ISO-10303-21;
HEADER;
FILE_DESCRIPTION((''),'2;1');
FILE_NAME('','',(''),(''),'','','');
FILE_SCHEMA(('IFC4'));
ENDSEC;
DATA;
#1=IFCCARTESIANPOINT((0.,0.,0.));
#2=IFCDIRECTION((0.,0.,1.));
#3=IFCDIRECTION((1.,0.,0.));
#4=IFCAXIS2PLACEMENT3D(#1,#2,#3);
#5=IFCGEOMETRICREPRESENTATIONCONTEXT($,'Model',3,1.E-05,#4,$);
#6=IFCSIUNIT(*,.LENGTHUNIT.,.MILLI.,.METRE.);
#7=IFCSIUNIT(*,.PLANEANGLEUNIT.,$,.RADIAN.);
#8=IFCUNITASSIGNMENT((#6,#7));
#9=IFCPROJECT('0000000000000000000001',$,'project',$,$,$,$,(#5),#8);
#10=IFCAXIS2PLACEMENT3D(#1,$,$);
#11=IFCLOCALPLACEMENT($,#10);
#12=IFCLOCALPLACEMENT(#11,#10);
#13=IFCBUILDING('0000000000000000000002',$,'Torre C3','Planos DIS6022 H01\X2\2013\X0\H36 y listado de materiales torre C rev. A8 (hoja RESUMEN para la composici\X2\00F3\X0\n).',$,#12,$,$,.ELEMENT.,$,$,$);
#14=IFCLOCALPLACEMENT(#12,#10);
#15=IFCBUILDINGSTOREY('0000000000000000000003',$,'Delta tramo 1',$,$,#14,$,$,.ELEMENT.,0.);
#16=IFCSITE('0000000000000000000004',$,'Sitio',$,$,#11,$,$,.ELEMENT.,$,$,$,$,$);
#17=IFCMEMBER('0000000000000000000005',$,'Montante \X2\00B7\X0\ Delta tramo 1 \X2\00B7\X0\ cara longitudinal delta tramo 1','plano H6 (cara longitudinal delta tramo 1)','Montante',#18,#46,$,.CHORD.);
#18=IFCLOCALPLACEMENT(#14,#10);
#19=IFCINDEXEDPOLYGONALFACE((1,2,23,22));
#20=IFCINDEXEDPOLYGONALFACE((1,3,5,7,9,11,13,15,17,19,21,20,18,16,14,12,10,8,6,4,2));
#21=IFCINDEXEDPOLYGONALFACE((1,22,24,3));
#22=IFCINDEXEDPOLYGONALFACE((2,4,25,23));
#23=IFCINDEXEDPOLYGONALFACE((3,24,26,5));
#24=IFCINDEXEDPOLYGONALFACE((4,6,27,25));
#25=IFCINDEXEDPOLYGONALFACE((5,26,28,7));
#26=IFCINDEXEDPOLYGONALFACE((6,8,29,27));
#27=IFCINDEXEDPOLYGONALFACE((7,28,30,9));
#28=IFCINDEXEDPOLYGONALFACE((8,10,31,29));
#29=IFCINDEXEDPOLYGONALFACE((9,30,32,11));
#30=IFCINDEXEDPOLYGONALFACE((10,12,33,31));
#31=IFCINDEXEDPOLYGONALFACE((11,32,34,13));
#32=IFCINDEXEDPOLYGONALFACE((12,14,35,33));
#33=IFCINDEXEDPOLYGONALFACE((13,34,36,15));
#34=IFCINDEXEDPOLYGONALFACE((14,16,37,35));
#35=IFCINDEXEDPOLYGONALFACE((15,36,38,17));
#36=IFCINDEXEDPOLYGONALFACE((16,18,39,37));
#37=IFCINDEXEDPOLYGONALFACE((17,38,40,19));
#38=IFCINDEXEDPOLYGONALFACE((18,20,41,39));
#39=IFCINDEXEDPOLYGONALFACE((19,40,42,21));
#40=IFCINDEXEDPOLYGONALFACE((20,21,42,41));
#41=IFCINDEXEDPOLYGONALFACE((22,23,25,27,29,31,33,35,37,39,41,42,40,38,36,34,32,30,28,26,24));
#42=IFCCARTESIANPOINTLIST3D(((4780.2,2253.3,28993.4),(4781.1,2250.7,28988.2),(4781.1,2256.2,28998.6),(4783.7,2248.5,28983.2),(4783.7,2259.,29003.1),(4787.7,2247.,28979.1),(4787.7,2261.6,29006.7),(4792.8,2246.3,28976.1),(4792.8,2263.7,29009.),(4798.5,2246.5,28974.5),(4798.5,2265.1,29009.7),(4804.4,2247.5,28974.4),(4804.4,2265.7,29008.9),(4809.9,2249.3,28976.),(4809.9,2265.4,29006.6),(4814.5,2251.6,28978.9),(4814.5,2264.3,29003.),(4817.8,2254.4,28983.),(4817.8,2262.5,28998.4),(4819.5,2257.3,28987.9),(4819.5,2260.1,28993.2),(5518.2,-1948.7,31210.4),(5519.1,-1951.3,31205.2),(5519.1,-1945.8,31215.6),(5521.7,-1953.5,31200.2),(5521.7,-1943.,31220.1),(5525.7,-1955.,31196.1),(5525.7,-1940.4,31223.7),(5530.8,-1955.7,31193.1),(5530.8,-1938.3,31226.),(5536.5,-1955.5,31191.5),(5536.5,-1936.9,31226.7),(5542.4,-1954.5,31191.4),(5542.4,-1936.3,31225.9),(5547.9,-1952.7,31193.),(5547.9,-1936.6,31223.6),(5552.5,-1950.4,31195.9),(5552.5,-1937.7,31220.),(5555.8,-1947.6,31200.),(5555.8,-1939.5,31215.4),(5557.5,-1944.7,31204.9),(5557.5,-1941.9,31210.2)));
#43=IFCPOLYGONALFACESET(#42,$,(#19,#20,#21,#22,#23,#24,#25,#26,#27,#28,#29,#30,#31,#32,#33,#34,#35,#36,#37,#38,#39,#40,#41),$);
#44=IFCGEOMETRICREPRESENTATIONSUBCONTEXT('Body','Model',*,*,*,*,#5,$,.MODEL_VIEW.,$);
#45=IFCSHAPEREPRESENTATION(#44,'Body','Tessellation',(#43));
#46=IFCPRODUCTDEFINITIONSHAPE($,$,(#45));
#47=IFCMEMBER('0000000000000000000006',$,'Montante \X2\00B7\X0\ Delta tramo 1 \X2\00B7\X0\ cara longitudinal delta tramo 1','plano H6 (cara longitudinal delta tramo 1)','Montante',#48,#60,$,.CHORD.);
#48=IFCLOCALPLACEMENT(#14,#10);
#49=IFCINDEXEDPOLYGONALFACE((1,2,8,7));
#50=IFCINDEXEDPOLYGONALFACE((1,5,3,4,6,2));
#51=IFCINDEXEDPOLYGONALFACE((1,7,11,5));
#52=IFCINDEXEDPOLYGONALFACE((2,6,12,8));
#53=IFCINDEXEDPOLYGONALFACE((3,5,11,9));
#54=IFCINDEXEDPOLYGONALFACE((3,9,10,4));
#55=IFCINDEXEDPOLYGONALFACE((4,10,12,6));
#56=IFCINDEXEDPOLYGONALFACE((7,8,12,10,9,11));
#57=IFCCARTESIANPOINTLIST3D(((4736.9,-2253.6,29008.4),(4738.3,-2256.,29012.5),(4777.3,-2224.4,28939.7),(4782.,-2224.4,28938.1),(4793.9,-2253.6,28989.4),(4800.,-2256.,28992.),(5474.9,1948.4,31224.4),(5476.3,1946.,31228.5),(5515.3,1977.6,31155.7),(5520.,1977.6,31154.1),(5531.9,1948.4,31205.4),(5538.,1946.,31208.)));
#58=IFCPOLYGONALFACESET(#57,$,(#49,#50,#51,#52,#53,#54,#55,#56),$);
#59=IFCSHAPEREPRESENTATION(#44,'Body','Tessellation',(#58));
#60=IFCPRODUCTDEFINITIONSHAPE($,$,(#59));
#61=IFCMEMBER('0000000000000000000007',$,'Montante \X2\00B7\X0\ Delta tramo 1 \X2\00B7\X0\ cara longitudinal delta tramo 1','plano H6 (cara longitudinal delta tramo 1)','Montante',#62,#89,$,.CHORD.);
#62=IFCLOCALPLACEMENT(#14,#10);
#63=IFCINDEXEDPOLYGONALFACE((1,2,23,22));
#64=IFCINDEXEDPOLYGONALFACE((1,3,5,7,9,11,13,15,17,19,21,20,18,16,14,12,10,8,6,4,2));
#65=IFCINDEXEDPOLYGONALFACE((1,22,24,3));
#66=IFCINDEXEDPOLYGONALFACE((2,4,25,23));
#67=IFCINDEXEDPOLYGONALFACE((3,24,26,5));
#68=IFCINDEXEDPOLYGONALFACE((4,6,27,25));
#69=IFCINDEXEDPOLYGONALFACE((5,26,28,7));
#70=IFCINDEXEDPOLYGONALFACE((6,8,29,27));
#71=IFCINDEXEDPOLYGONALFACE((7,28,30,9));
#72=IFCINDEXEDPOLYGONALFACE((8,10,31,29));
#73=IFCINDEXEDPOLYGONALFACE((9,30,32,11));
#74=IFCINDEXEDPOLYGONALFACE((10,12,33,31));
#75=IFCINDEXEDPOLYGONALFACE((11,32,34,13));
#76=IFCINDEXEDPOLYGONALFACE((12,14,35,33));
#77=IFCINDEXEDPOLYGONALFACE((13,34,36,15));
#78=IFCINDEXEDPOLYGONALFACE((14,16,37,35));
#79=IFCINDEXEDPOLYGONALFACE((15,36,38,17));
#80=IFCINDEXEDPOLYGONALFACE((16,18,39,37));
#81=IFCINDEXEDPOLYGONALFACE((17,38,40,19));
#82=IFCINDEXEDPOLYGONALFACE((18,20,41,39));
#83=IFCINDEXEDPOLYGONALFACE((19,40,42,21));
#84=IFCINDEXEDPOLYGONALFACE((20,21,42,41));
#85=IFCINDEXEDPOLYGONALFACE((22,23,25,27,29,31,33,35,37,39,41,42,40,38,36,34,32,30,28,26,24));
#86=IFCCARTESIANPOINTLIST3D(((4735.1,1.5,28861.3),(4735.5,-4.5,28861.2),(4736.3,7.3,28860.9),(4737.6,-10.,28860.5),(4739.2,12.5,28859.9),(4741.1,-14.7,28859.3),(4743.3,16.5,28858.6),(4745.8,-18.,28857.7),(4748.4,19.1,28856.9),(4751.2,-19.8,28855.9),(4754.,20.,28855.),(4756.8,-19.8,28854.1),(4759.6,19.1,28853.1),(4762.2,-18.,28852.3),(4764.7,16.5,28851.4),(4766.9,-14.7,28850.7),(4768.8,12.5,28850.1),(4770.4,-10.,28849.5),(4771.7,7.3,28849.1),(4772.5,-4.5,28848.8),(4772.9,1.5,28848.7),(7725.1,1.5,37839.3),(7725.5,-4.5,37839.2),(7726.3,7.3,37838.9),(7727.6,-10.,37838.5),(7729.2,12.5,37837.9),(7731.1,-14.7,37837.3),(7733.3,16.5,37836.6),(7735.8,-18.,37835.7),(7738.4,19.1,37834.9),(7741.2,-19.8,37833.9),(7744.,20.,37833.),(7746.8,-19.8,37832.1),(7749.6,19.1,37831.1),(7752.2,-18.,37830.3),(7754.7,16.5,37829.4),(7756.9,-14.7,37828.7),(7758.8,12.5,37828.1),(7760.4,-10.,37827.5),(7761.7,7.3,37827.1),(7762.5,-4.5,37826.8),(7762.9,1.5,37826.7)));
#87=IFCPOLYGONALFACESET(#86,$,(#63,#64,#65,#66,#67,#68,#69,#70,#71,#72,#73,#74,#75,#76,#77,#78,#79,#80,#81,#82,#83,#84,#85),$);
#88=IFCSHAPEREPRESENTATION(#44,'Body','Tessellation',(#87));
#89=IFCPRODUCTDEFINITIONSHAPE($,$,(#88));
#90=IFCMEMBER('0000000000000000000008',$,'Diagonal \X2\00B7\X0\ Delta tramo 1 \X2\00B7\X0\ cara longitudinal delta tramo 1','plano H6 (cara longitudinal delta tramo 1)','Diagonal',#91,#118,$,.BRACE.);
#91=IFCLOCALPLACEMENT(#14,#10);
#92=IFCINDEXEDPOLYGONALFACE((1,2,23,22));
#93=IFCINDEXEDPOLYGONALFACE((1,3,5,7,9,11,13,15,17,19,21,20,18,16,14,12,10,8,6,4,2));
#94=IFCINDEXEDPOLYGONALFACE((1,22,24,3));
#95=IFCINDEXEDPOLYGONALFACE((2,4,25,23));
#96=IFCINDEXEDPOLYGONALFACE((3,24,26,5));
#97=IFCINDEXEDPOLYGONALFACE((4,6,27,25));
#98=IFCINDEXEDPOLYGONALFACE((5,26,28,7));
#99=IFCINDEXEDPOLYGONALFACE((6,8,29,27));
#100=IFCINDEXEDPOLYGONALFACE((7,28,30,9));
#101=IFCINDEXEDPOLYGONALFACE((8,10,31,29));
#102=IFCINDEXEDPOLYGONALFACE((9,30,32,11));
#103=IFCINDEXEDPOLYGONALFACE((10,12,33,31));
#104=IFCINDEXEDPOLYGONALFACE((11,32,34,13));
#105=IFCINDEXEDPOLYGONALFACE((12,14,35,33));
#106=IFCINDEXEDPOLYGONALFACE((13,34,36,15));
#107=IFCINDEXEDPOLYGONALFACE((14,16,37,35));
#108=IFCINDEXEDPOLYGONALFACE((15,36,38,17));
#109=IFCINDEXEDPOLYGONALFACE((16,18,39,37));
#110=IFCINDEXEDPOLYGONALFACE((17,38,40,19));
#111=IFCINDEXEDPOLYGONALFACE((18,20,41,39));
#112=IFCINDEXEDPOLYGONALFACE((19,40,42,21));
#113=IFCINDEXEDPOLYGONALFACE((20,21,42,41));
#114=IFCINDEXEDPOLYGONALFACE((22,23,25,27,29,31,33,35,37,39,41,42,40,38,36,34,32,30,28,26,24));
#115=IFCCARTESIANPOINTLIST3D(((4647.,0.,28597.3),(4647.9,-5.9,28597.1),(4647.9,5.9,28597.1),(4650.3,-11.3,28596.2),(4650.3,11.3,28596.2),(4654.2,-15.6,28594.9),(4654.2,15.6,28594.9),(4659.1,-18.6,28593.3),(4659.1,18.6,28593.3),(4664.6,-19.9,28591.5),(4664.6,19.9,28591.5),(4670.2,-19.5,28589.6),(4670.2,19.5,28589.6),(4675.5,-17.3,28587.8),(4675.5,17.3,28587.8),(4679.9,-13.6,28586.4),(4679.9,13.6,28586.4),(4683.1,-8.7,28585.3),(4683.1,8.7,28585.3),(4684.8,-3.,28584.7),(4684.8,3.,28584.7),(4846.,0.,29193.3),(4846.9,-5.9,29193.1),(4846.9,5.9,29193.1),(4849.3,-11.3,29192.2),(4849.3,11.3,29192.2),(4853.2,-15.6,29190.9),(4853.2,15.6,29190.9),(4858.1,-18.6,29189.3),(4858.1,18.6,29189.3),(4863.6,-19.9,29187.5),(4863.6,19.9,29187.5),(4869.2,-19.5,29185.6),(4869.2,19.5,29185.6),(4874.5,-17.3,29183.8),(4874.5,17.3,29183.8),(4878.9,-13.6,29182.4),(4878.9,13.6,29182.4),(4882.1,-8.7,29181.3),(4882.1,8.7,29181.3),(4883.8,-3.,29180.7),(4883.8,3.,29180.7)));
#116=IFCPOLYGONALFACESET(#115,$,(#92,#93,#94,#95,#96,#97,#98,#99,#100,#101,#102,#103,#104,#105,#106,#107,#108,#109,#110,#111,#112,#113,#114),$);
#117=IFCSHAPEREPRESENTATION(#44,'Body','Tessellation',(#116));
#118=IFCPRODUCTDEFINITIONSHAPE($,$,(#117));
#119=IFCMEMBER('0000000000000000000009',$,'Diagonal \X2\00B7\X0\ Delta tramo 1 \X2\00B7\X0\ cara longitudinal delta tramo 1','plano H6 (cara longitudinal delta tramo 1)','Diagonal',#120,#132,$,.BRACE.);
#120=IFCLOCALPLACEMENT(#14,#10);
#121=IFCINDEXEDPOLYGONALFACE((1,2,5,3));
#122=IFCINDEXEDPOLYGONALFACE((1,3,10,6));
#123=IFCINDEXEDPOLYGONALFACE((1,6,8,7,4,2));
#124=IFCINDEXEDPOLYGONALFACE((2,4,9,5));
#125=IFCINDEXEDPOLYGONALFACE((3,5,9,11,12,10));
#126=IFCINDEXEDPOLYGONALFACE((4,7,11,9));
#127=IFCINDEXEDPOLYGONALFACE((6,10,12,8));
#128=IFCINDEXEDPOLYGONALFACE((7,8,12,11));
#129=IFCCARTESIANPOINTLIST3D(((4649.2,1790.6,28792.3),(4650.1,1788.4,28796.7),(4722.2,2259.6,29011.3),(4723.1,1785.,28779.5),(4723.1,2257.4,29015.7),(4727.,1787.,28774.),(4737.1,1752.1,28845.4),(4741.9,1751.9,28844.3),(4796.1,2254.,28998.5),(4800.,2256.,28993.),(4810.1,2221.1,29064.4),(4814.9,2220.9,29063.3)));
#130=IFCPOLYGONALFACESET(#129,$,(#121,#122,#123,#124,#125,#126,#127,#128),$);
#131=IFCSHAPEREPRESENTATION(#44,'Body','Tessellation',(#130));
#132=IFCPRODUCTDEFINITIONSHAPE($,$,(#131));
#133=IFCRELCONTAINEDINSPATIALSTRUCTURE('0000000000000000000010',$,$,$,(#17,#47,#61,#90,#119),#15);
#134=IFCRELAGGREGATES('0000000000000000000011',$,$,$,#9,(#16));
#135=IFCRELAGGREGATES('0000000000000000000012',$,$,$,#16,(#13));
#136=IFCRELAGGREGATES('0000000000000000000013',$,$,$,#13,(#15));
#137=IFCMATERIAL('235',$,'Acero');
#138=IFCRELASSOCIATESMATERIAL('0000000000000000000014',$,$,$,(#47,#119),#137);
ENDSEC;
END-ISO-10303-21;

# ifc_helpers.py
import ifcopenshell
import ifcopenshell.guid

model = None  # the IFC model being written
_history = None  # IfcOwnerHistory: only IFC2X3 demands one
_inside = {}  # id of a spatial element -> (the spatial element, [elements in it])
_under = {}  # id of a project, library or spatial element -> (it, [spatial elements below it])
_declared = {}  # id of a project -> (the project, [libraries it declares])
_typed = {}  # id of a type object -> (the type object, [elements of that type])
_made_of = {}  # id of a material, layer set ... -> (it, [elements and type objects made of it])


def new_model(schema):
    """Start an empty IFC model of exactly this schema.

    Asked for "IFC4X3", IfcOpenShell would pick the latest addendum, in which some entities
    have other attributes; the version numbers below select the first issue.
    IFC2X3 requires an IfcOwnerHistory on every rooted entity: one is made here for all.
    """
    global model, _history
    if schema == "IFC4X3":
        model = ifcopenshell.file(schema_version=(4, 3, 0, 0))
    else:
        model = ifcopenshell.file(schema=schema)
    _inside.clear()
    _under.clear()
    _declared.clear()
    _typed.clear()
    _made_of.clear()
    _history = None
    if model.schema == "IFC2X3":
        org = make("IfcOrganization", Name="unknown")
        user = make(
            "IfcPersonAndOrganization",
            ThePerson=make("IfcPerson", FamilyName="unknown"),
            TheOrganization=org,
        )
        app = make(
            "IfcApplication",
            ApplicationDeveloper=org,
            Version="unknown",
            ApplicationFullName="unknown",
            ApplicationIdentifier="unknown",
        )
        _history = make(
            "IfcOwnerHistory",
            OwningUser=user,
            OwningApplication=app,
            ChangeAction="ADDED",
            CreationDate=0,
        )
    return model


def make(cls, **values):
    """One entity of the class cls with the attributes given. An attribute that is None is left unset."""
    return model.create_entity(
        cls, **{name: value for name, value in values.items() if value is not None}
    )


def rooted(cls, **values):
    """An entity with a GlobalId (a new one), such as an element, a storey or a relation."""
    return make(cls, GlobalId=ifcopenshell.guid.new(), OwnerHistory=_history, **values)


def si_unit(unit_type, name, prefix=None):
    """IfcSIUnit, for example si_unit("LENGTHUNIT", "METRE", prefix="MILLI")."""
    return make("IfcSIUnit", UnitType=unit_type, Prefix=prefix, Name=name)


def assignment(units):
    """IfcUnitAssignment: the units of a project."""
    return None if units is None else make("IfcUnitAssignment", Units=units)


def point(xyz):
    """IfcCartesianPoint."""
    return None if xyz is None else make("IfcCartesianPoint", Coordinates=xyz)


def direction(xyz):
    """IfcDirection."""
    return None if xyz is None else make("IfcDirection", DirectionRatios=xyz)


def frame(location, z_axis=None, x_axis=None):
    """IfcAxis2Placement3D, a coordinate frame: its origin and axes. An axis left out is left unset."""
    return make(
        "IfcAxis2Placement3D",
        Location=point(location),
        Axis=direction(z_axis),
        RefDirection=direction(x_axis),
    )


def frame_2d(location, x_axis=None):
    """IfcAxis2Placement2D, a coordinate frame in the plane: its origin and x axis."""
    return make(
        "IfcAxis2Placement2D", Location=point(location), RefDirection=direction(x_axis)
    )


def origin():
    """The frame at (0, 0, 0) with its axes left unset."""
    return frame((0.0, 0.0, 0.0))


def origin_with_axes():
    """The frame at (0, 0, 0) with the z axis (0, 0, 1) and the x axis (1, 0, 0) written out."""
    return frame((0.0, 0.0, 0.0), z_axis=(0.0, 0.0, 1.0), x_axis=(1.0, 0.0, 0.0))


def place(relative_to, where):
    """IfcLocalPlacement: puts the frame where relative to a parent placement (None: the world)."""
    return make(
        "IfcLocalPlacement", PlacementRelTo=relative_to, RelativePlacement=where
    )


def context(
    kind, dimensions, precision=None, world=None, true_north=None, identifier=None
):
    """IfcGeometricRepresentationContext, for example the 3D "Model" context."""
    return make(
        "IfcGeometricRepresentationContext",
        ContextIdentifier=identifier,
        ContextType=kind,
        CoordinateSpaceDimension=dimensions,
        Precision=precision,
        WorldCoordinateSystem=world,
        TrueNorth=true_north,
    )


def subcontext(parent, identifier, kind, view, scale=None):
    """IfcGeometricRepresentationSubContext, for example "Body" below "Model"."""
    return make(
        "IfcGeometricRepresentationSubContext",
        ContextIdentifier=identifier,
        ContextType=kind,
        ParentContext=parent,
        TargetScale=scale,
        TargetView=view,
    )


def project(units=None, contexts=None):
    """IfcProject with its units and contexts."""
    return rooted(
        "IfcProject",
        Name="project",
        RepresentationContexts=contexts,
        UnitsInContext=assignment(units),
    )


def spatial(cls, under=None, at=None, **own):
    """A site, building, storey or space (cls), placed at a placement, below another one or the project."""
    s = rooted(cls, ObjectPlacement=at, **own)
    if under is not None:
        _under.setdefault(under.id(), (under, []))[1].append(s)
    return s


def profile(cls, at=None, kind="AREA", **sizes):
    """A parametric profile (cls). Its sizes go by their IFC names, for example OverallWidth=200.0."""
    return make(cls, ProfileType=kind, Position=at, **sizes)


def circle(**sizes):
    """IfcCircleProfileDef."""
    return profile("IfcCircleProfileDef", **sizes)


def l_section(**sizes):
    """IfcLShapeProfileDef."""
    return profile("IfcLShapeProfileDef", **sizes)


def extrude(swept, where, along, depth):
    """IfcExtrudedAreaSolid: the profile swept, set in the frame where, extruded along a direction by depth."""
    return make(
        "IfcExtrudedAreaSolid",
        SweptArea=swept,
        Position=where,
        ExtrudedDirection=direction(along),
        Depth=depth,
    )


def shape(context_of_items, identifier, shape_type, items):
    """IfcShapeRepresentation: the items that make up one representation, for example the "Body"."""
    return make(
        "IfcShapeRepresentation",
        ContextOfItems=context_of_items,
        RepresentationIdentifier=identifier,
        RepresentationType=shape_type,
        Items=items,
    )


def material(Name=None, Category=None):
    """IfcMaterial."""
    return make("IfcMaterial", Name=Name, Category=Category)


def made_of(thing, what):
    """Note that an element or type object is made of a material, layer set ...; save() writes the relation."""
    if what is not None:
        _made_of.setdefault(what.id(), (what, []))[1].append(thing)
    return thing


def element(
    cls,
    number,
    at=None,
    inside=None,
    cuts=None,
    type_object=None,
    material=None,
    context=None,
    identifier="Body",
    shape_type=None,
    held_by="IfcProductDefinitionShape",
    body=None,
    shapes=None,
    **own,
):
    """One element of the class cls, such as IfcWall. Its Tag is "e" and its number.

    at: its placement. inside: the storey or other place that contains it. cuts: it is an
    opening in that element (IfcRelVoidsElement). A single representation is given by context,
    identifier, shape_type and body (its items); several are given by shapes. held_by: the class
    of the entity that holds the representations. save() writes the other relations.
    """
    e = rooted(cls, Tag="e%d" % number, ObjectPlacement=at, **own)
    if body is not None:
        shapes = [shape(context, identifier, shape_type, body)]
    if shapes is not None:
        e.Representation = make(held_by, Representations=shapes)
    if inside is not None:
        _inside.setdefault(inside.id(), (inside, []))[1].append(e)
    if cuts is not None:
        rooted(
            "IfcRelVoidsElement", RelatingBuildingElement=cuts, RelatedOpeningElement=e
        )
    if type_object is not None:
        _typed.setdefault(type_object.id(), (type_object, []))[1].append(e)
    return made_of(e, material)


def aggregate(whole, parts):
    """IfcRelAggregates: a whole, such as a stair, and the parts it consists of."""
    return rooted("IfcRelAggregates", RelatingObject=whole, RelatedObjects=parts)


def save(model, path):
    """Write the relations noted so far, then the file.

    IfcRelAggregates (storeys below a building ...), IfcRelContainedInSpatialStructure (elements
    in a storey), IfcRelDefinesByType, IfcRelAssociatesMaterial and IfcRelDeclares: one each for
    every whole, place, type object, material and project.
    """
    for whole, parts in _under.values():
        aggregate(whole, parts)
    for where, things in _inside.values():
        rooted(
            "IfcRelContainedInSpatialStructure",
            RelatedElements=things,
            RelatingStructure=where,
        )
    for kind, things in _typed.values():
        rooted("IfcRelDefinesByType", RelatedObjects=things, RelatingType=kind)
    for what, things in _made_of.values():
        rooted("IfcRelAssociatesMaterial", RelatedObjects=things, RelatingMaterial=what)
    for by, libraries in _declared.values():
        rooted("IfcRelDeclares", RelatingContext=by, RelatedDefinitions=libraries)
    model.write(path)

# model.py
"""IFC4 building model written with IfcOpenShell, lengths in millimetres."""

from ifc_helpers import new_model, si_unit, frame, frame_2d, origin, origin_with_axes, place, context, subcontext, project, spatial, circle, l_section, extrude, material, element, save


model = new_model("IFC4")

# Units and contexts
model_context = context("Model", 3, precision=1e-05, world=origin_with_axes())
body_context = subcontext(model_context, "Body", "Model", "MODEL_VIEW")
ifc_project = project(units=[si_unit("LENGTHUNIT", "METRE", prefix="MILLI"), si_unit("PLANEANGLEUNIT", "RADIAN")], contexts=[model_context])

# Site, building, storey
site_placement = place(None, origin())
site = spatial("IfcSite", under=ifc_project, at=site_placement, Name="Sitio", CompositionType="ELEMENT")
building_placement = place(site_placement, origin())
building = spatial("IfcBuilding", under=site, at=building_placement, Name="Torre C3", Description="Planos DIS6022 H01–H36 y listado de materiales torre C rev. A8 (hoja RESUMEN para la composición).", CompositionType="ELEMENT")
storey_placement = place(building_placement, origin())
storey = spatial("IfcBuildingStorey", under=building, at=storey_placement, Name="Delta tramo 1", CompositionType="ELEMENT", Elevation=0.0)

# Members
member_1_placement = place(storey_placement, frame((4800.0, 2256.0, 28992.0), z_axis=(0.153495, -0.873966, 0.46111), x_axis=(-0.988149, -0.135759, 0.071627)))
element("IfcMember", 1, at=member_1_placement, inside=storey, Name="Montante · Delta tramo 1 · cara longitudinal delta tramo 1", Description="plano H6 (cara longitudinal delta tramo 1)", ObjectType="Montante", PredefinedType="CHORD", context=body_context, shape_type="SweptSolid", body=[
    extrude(circle(Radius=20.0), None, (0.0, 0.0, 1.0), 4808.0),
])
ifc_material_1 = material(Name="235", Category="Acero")
member_2_placement = place(storey_placement, frame((4800.0, -2256.0, 28992.0), z_axis=(0.15351, 0.87405, 0.460946), x_axis=(-0.276174, 0.485836, -0.829272)))
element("IfcMember", 2, at=member_2_placement, inside=storey, material=ifc_material_1, Name="Montante · Delta tramo 1 · cara longitudinal delta tramo 1", Description="plano H6 (cara longitudinal delta tramo 1)", ObjectType="Montante", PredefinedType="CHORD", context=body_context, shape_type="SweptSolid", body=[
    extrude(l_section(Depth=65.0, Width=65.0, Thickness=5.0, at=frame_2d((32.5, 32.5))), None, (0.0, 0.0, 1.0), 4807.5),
])
member_3_placement = place(storey_placement, frame((4754.0, 0.0, 28855.0), z_axis=(0.315974, 0.0, 0.948768), x_axis=(0.0, 1.0, 0.0)))
element("IfcMember", 3, at=member_3_placement, inside=storey, Name="Montante · Delta tramo 1 · cara longitudinal delta tramo 1", Description="plano H6 (cara longitudinal delta tramo 1)", ObjectType="Montante", PredefinedType="CHORD", context=body_context, shape_type="SweptSolid", body=[
    extrude(circle(Radius=20.0), None, (0.0, 0.0, 1.0), 9462.8),
])
member_4_placement = place(storey_placement, frame((4666.0, 0.0, 28591.0), z_axis=(0.316705, 0.0, 0.948524), x_axis=(-0.948524, 0.0, 0.316705)))
element("IfcMember", 4, at=member_4_placement, inside=storey, Name="Diagonal · Delta tramo 1 · cara longitudinal delta tramo 1", Description="plano H6 (cara longitudinal delta tramo 1)", ObjectType="Diagonal", PredefinedType="BRACE", context=body_context, shape_type="SweptSolid", body=[
    extrude(circle(Radius=20.0), None, (0.0, 0.0, 1.0), 628.3),
])
member_5_placement = place(storey_placement, frame((4727.0, 1787.0, 28774.0), z_axis=(0.13965, 0.897206, 0.418951), x_axis=(-0.972489, 0.044604, 0.22864)))
element("IfcMember", 5, at=member_5_placement, inside=storey, material=ifc_material_1, Name="Diagonal · Delta tramo 1 · cara longitudinal delta tramo 1", Description="plano H6 (cara longitudinal delta tramo 1)", ObjectType="Diagonal", PredefinedType="BRACE", context=body_context, shape_type="SweptSolid", body=[
    extrude(l_section(Depth=80.0, Width=80.0, Thickness=5.0, at=frame_2d((40.0, 40.0))), None, (0.0, 0.0, 1.0), 522.7),
])

save(model, "model.ifc")
